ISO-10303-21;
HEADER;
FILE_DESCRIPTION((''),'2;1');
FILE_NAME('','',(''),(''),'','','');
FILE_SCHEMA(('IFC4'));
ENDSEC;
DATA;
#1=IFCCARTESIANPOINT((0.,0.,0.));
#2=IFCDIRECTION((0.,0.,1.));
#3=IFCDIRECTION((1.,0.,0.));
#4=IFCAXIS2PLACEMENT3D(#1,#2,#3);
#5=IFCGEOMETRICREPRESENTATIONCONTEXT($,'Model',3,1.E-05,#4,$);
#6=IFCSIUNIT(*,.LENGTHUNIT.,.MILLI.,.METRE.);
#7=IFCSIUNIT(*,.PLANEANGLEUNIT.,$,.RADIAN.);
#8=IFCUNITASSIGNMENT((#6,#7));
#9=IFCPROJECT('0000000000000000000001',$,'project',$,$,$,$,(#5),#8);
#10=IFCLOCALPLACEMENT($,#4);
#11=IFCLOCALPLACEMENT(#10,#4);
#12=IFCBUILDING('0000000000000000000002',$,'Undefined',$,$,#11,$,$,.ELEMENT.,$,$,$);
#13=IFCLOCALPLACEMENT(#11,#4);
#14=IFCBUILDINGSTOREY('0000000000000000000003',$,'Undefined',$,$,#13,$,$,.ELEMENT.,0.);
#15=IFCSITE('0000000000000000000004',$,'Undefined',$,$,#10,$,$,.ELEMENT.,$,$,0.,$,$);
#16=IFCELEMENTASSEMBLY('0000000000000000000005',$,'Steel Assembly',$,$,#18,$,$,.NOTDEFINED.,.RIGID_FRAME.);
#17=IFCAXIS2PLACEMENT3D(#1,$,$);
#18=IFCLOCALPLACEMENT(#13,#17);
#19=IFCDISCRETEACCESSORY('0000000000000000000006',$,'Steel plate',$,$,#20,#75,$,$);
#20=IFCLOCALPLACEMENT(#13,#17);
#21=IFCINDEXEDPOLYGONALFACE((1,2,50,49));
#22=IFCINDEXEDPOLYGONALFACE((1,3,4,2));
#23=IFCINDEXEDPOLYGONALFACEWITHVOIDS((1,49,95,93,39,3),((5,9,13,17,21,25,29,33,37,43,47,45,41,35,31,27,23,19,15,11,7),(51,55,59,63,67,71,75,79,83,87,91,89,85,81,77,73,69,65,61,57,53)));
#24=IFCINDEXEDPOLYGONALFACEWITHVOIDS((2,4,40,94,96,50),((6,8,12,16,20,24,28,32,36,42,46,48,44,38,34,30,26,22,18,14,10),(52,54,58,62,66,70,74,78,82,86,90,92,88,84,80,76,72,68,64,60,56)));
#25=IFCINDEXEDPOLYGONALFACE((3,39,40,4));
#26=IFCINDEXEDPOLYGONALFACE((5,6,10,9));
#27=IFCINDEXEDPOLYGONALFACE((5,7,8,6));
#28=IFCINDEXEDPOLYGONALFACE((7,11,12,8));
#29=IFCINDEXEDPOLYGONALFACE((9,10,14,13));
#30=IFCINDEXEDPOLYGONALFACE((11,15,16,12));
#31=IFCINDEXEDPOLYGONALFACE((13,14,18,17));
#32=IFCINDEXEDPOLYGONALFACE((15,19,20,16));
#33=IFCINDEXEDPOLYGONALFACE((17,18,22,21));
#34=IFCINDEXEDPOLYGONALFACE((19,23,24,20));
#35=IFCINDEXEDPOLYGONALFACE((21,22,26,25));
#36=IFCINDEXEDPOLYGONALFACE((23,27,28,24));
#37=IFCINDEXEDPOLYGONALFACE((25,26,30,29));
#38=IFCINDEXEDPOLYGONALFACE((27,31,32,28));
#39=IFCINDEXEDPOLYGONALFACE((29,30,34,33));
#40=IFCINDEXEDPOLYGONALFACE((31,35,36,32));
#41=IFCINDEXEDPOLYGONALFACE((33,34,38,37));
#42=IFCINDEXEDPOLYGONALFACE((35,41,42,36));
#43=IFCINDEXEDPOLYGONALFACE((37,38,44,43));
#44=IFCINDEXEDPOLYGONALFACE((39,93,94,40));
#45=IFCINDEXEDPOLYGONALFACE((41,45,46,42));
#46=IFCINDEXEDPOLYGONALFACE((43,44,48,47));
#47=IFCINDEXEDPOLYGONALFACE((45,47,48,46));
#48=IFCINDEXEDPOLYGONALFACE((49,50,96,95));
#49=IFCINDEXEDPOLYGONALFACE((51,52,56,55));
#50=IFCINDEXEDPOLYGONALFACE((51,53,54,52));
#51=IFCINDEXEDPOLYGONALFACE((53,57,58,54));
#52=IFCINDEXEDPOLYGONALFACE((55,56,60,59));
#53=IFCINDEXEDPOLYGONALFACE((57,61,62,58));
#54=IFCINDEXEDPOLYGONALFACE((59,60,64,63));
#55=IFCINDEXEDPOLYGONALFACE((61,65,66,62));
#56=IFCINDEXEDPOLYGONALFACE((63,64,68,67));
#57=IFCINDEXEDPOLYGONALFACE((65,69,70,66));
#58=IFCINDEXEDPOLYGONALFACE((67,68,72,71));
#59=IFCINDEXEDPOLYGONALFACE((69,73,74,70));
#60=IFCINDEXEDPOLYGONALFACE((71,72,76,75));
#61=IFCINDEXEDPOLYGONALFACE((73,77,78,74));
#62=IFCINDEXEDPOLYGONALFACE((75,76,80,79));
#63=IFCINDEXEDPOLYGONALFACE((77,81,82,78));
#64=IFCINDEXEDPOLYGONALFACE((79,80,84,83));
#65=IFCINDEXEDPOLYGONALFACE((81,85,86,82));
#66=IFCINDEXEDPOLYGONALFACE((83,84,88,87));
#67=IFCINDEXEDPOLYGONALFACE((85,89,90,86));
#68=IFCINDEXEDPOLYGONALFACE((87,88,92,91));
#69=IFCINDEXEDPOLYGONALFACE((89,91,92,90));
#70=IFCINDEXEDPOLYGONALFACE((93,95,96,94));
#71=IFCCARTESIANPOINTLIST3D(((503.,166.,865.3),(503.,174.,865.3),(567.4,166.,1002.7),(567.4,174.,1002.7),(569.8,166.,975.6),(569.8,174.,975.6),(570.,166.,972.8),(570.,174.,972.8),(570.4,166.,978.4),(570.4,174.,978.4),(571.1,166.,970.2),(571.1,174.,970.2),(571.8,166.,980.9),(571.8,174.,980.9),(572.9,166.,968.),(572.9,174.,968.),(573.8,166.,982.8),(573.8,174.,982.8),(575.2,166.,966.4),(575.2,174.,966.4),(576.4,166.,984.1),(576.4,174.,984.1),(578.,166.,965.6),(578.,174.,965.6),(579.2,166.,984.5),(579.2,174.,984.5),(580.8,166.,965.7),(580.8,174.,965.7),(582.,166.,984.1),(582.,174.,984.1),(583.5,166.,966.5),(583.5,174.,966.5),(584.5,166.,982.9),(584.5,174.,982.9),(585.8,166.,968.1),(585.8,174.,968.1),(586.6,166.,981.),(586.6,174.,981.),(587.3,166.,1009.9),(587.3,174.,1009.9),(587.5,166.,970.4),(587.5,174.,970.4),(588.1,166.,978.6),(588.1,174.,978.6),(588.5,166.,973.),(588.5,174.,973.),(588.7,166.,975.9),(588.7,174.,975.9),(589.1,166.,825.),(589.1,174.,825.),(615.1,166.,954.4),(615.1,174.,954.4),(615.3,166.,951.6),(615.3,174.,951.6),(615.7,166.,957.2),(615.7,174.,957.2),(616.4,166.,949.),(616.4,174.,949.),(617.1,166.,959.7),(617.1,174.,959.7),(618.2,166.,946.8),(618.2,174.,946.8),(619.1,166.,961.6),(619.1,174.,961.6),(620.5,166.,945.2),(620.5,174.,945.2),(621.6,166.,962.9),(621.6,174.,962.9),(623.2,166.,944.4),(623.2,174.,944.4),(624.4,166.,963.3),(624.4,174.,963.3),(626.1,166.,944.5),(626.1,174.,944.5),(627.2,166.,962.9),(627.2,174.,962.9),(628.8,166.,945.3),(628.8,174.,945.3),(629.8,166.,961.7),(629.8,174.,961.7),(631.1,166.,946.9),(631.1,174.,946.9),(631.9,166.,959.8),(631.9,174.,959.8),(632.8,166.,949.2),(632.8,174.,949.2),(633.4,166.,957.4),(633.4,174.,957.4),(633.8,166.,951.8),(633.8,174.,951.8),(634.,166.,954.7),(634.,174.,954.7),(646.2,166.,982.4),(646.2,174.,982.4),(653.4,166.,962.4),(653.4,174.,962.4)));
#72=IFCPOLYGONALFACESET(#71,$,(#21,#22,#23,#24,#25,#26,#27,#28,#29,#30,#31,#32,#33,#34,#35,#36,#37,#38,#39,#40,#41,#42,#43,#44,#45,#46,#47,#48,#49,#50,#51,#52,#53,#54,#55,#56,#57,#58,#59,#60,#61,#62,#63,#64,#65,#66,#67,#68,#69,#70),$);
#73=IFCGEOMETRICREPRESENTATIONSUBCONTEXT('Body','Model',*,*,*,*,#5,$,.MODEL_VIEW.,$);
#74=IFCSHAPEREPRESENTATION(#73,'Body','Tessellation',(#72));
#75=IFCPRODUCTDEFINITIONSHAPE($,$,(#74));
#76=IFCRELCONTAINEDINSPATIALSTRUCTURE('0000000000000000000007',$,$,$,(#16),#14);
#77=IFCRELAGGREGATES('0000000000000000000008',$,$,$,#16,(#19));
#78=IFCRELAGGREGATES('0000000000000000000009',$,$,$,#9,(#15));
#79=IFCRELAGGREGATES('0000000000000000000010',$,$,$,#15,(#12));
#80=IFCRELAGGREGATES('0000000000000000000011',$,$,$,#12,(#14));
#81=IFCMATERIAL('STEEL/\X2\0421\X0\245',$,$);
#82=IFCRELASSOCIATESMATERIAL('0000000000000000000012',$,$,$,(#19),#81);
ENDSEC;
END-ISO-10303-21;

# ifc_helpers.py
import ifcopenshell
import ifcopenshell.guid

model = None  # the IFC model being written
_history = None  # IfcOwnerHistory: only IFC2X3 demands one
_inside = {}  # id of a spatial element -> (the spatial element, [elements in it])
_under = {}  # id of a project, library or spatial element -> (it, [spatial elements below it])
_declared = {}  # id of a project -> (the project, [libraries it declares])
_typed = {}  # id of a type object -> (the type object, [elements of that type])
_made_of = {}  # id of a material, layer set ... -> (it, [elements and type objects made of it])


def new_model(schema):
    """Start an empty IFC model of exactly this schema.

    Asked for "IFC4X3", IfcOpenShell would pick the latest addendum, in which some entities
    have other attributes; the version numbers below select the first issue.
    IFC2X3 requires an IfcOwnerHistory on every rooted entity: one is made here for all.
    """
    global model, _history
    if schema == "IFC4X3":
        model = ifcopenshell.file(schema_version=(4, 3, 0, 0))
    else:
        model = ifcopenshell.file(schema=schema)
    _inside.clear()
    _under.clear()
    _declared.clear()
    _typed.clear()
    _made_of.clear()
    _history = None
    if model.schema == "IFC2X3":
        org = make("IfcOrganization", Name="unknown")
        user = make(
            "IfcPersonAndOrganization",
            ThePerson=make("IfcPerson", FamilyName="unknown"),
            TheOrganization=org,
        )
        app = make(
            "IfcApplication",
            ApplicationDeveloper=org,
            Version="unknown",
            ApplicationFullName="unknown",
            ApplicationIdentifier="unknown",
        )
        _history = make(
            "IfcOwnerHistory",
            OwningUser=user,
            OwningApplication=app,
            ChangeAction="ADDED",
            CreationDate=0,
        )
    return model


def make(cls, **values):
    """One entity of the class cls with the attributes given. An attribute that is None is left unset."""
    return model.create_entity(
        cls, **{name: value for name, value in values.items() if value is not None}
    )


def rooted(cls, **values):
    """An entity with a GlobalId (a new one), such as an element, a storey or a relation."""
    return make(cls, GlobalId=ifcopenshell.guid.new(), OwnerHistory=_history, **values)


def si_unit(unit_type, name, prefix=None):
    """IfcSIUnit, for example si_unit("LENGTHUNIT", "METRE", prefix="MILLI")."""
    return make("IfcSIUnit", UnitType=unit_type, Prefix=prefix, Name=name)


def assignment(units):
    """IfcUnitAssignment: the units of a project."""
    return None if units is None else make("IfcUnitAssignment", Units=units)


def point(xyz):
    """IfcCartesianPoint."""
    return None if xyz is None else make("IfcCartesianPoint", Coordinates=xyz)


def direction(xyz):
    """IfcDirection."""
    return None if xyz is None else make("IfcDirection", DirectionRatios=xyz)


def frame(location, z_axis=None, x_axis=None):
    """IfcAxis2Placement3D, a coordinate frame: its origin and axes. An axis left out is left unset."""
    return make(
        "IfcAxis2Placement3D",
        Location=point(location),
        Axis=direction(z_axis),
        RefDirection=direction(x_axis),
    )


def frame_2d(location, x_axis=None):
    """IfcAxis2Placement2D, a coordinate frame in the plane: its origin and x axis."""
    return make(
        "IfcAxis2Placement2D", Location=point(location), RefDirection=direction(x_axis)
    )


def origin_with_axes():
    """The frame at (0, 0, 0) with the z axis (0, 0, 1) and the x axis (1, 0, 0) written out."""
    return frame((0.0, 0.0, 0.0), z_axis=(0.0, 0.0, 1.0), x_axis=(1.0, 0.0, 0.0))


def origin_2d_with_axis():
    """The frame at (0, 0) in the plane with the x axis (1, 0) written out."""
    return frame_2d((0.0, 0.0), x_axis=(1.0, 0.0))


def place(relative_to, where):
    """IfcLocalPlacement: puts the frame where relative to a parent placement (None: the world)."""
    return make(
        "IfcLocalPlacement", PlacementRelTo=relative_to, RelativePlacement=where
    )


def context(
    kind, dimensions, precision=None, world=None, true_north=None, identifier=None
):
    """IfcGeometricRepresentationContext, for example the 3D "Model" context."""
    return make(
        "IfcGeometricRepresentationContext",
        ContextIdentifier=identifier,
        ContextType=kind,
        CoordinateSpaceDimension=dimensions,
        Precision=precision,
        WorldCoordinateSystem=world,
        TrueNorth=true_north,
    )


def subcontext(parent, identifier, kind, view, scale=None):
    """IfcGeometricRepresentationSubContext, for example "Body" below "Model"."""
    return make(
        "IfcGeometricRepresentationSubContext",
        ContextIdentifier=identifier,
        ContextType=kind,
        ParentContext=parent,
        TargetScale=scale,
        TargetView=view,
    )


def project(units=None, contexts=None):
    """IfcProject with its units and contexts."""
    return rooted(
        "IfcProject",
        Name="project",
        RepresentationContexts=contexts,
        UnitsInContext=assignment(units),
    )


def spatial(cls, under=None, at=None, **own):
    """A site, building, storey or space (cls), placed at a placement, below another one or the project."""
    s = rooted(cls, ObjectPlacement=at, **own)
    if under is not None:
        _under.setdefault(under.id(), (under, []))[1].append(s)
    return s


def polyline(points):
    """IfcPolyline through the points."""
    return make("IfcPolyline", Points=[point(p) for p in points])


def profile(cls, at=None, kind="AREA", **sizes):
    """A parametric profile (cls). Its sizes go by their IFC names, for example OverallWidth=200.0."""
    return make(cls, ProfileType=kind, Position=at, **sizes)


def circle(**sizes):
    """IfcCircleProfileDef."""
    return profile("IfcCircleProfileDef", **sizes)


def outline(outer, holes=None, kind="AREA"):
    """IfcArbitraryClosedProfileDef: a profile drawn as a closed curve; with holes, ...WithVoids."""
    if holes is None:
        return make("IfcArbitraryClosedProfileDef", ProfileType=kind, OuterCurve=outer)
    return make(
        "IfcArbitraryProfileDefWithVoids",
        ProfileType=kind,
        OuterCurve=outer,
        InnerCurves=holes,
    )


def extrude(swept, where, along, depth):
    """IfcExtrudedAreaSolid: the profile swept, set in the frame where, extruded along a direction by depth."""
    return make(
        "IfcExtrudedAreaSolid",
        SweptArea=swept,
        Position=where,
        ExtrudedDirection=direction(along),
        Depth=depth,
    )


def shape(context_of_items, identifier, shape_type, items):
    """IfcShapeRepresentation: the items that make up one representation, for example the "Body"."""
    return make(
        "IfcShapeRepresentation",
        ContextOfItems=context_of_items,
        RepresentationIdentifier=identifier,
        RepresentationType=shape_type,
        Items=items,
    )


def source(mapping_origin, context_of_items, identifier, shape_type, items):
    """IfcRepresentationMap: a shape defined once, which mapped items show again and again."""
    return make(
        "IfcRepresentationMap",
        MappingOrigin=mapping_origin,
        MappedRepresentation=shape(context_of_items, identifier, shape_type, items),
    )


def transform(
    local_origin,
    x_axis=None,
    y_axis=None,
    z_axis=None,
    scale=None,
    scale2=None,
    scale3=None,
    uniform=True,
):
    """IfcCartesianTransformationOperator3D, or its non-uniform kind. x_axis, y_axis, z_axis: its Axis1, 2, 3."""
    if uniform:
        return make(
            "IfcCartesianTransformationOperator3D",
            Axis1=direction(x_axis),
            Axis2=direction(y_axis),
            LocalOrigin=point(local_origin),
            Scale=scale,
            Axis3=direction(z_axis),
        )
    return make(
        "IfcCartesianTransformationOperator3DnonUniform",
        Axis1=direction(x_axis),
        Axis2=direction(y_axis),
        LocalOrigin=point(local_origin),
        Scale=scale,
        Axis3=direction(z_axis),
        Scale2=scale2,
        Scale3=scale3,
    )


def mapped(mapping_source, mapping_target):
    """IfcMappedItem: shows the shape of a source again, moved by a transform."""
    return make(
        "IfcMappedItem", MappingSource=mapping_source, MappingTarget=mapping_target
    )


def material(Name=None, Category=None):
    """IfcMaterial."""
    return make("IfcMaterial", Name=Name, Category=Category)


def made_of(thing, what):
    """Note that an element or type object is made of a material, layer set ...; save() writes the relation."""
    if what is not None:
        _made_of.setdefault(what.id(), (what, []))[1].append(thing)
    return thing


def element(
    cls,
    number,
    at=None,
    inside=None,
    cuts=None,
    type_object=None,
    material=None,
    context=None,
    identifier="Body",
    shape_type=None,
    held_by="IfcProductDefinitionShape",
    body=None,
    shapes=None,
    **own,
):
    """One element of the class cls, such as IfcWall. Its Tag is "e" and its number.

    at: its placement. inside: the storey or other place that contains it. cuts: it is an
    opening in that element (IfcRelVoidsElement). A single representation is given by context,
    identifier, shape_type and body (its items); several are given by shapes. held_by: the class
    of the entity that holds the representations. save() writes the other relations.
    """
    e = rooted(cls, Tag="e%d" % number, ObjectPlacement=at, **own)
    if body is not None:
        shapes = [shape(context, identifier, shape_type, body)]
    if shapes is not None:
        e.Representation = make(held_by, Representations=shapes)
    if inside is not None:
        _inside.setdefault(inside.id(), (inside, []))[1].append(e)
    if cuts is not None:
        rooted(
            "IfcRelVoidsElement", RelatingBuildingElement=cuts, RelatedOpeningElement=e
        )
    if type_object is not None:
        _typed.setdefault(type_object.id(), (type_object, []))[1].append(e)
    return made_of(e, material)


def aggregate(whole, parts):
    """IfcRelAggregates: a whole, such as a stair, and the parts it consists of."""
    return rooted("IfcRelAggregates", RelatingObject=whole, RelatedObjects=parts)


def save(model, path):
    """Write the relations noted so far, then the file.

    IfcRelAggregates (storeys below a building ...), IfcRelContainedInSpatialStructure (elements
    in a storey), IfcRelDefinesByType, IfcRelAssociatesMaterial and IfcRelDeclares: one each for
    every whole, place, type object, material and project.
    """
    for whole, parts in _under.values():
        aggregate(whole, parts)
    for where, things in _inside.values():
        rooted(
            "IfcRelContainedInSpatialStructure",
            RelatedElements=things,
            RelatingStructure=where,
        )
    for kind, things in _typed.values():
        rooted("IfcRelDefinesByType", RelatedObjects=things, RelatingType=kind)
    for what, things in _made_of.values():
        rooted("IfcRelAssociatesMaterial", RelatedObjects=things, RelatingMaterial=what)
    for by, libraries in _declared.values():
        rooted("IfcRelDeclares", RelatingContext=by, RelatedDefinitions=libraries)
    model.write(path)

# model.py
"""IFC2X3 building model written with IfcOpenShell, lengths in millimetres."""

from ifc_helpers import new_model, si_unit, frame, origin_with_axes, origin_2d_with_axis, place, context, subcontext, project, spatial, polyline, circle, outline, extrude, source, transform, mapped, material, element, aggregate, save


model = new_model("IFC2X3")

# Units and contexts
model_context = context("Model", 3, precision=1e-05, world=origin_with_axes())
body_context = subcontext(model_context, "Body", "Model", "MODEL_VIEW")
ifc_project = project(units=[si_unit("LENGTHUNIT", "METRE", prefix="MILLI"), si_unit("PLANEANGLEUNIT", "RADIAN")], contexts=[model_context])

# Site, building, storey
site_placement = place(None, origin_with_axes())
site = spatial("IfcSite", under=ifc_project, at=site_placement, Name="Undefined", CompositionType="ELEMENT", RefElevation=0.0)
building_placement = place(site_placement, origin_with_axes())
building = spatial("IfcBuilding", under=site, at=building_placement, Name="Undefined", CompositionType="ELEMENT")
storey_placement = place(building_placement, origin_with_axes())
storey = spatial("IfcBuildingStorey", under=building, at=storey_placement, Name="Undefined", CompositionType="ELEMENT", Elevation=0.0)

# Element assembly
assembly_1_placement = place(storey_placement, origin_with_axes())
assembly_1 = element("IfcElementAssembly", 1, at=assembly_1_placement, inside=storey, Name="Steel Assembly", AssemblyPlace="NOTDEFINED", PredefinedType="RIGID_FRAME")

# Shared definitions
ifc_material_1 = material(Name="STEEL/С245")

# Discrete accessory, opening
shared_shape_1 = source(origin_with_axes(), body_context, "Body", "SweptSolid", [
    extrude(circle(Radius=9.5, at=origin_2d_with_axis()), frame((0.0, -4.1, 0.0), z_axis=(0.0, 1.0, 0.0), x_axis=(1.0, 0.0, 0.0)), (0.0, 0.0, 1.0), 12.3),
])
discrete_accessory_1_placement = place(assembly_1_placement, frame((659.8, 170.0, 976.0), z_axis=(0.0, -1.0, 0.0), x_axis=(-0.905659, 0.0, 0.424008)))
discrete_accessory_1 = element("IfcDiscreteAccessory", 2, at=discrete_accessory_1_placement, material=ifc_material_1, Name="Steel plate", context=body_context, shape_type="SweptSolid", body=[
    extrude(outline(polyline([(0.0, 15.0), (15.0, 0.0), (80.0, 0.0), (95.0, 15.0), (95.0, 166.7), (0.0, 166.7), (0.0, 15.0)])), frame((0.0, 0.0, -4.0), z_axis=(0.0, 0.0, 1.0), x_axis=(1.0, 0.0, 0.0)), (0.0, 0.0, 1.0), 8.0),
])
opening_1_placement = place(assembly_1_placement, frame((601.9, 170.0, 964.4), z_axis=(0.905659, 0.0, -0.424008), x_axis=(-0.424008, 0.0, -0.905659)))
element("IfcOpeningElement", 3, at=opening_1_placement, cuts=discrete_accessory_1, ObjectType="Opening", context=body_context, shape_type="MappedRepresentation", body=[
    mapped(shared_shape_1, transform((0.0, 0.0, -25.0))),
    mapped(shared_shape_1, transform((0.0, 0.0, 25.0))),
])

aggregate(assembly_1, [discrete_accessory_1])

save(model, "model.ifc")
